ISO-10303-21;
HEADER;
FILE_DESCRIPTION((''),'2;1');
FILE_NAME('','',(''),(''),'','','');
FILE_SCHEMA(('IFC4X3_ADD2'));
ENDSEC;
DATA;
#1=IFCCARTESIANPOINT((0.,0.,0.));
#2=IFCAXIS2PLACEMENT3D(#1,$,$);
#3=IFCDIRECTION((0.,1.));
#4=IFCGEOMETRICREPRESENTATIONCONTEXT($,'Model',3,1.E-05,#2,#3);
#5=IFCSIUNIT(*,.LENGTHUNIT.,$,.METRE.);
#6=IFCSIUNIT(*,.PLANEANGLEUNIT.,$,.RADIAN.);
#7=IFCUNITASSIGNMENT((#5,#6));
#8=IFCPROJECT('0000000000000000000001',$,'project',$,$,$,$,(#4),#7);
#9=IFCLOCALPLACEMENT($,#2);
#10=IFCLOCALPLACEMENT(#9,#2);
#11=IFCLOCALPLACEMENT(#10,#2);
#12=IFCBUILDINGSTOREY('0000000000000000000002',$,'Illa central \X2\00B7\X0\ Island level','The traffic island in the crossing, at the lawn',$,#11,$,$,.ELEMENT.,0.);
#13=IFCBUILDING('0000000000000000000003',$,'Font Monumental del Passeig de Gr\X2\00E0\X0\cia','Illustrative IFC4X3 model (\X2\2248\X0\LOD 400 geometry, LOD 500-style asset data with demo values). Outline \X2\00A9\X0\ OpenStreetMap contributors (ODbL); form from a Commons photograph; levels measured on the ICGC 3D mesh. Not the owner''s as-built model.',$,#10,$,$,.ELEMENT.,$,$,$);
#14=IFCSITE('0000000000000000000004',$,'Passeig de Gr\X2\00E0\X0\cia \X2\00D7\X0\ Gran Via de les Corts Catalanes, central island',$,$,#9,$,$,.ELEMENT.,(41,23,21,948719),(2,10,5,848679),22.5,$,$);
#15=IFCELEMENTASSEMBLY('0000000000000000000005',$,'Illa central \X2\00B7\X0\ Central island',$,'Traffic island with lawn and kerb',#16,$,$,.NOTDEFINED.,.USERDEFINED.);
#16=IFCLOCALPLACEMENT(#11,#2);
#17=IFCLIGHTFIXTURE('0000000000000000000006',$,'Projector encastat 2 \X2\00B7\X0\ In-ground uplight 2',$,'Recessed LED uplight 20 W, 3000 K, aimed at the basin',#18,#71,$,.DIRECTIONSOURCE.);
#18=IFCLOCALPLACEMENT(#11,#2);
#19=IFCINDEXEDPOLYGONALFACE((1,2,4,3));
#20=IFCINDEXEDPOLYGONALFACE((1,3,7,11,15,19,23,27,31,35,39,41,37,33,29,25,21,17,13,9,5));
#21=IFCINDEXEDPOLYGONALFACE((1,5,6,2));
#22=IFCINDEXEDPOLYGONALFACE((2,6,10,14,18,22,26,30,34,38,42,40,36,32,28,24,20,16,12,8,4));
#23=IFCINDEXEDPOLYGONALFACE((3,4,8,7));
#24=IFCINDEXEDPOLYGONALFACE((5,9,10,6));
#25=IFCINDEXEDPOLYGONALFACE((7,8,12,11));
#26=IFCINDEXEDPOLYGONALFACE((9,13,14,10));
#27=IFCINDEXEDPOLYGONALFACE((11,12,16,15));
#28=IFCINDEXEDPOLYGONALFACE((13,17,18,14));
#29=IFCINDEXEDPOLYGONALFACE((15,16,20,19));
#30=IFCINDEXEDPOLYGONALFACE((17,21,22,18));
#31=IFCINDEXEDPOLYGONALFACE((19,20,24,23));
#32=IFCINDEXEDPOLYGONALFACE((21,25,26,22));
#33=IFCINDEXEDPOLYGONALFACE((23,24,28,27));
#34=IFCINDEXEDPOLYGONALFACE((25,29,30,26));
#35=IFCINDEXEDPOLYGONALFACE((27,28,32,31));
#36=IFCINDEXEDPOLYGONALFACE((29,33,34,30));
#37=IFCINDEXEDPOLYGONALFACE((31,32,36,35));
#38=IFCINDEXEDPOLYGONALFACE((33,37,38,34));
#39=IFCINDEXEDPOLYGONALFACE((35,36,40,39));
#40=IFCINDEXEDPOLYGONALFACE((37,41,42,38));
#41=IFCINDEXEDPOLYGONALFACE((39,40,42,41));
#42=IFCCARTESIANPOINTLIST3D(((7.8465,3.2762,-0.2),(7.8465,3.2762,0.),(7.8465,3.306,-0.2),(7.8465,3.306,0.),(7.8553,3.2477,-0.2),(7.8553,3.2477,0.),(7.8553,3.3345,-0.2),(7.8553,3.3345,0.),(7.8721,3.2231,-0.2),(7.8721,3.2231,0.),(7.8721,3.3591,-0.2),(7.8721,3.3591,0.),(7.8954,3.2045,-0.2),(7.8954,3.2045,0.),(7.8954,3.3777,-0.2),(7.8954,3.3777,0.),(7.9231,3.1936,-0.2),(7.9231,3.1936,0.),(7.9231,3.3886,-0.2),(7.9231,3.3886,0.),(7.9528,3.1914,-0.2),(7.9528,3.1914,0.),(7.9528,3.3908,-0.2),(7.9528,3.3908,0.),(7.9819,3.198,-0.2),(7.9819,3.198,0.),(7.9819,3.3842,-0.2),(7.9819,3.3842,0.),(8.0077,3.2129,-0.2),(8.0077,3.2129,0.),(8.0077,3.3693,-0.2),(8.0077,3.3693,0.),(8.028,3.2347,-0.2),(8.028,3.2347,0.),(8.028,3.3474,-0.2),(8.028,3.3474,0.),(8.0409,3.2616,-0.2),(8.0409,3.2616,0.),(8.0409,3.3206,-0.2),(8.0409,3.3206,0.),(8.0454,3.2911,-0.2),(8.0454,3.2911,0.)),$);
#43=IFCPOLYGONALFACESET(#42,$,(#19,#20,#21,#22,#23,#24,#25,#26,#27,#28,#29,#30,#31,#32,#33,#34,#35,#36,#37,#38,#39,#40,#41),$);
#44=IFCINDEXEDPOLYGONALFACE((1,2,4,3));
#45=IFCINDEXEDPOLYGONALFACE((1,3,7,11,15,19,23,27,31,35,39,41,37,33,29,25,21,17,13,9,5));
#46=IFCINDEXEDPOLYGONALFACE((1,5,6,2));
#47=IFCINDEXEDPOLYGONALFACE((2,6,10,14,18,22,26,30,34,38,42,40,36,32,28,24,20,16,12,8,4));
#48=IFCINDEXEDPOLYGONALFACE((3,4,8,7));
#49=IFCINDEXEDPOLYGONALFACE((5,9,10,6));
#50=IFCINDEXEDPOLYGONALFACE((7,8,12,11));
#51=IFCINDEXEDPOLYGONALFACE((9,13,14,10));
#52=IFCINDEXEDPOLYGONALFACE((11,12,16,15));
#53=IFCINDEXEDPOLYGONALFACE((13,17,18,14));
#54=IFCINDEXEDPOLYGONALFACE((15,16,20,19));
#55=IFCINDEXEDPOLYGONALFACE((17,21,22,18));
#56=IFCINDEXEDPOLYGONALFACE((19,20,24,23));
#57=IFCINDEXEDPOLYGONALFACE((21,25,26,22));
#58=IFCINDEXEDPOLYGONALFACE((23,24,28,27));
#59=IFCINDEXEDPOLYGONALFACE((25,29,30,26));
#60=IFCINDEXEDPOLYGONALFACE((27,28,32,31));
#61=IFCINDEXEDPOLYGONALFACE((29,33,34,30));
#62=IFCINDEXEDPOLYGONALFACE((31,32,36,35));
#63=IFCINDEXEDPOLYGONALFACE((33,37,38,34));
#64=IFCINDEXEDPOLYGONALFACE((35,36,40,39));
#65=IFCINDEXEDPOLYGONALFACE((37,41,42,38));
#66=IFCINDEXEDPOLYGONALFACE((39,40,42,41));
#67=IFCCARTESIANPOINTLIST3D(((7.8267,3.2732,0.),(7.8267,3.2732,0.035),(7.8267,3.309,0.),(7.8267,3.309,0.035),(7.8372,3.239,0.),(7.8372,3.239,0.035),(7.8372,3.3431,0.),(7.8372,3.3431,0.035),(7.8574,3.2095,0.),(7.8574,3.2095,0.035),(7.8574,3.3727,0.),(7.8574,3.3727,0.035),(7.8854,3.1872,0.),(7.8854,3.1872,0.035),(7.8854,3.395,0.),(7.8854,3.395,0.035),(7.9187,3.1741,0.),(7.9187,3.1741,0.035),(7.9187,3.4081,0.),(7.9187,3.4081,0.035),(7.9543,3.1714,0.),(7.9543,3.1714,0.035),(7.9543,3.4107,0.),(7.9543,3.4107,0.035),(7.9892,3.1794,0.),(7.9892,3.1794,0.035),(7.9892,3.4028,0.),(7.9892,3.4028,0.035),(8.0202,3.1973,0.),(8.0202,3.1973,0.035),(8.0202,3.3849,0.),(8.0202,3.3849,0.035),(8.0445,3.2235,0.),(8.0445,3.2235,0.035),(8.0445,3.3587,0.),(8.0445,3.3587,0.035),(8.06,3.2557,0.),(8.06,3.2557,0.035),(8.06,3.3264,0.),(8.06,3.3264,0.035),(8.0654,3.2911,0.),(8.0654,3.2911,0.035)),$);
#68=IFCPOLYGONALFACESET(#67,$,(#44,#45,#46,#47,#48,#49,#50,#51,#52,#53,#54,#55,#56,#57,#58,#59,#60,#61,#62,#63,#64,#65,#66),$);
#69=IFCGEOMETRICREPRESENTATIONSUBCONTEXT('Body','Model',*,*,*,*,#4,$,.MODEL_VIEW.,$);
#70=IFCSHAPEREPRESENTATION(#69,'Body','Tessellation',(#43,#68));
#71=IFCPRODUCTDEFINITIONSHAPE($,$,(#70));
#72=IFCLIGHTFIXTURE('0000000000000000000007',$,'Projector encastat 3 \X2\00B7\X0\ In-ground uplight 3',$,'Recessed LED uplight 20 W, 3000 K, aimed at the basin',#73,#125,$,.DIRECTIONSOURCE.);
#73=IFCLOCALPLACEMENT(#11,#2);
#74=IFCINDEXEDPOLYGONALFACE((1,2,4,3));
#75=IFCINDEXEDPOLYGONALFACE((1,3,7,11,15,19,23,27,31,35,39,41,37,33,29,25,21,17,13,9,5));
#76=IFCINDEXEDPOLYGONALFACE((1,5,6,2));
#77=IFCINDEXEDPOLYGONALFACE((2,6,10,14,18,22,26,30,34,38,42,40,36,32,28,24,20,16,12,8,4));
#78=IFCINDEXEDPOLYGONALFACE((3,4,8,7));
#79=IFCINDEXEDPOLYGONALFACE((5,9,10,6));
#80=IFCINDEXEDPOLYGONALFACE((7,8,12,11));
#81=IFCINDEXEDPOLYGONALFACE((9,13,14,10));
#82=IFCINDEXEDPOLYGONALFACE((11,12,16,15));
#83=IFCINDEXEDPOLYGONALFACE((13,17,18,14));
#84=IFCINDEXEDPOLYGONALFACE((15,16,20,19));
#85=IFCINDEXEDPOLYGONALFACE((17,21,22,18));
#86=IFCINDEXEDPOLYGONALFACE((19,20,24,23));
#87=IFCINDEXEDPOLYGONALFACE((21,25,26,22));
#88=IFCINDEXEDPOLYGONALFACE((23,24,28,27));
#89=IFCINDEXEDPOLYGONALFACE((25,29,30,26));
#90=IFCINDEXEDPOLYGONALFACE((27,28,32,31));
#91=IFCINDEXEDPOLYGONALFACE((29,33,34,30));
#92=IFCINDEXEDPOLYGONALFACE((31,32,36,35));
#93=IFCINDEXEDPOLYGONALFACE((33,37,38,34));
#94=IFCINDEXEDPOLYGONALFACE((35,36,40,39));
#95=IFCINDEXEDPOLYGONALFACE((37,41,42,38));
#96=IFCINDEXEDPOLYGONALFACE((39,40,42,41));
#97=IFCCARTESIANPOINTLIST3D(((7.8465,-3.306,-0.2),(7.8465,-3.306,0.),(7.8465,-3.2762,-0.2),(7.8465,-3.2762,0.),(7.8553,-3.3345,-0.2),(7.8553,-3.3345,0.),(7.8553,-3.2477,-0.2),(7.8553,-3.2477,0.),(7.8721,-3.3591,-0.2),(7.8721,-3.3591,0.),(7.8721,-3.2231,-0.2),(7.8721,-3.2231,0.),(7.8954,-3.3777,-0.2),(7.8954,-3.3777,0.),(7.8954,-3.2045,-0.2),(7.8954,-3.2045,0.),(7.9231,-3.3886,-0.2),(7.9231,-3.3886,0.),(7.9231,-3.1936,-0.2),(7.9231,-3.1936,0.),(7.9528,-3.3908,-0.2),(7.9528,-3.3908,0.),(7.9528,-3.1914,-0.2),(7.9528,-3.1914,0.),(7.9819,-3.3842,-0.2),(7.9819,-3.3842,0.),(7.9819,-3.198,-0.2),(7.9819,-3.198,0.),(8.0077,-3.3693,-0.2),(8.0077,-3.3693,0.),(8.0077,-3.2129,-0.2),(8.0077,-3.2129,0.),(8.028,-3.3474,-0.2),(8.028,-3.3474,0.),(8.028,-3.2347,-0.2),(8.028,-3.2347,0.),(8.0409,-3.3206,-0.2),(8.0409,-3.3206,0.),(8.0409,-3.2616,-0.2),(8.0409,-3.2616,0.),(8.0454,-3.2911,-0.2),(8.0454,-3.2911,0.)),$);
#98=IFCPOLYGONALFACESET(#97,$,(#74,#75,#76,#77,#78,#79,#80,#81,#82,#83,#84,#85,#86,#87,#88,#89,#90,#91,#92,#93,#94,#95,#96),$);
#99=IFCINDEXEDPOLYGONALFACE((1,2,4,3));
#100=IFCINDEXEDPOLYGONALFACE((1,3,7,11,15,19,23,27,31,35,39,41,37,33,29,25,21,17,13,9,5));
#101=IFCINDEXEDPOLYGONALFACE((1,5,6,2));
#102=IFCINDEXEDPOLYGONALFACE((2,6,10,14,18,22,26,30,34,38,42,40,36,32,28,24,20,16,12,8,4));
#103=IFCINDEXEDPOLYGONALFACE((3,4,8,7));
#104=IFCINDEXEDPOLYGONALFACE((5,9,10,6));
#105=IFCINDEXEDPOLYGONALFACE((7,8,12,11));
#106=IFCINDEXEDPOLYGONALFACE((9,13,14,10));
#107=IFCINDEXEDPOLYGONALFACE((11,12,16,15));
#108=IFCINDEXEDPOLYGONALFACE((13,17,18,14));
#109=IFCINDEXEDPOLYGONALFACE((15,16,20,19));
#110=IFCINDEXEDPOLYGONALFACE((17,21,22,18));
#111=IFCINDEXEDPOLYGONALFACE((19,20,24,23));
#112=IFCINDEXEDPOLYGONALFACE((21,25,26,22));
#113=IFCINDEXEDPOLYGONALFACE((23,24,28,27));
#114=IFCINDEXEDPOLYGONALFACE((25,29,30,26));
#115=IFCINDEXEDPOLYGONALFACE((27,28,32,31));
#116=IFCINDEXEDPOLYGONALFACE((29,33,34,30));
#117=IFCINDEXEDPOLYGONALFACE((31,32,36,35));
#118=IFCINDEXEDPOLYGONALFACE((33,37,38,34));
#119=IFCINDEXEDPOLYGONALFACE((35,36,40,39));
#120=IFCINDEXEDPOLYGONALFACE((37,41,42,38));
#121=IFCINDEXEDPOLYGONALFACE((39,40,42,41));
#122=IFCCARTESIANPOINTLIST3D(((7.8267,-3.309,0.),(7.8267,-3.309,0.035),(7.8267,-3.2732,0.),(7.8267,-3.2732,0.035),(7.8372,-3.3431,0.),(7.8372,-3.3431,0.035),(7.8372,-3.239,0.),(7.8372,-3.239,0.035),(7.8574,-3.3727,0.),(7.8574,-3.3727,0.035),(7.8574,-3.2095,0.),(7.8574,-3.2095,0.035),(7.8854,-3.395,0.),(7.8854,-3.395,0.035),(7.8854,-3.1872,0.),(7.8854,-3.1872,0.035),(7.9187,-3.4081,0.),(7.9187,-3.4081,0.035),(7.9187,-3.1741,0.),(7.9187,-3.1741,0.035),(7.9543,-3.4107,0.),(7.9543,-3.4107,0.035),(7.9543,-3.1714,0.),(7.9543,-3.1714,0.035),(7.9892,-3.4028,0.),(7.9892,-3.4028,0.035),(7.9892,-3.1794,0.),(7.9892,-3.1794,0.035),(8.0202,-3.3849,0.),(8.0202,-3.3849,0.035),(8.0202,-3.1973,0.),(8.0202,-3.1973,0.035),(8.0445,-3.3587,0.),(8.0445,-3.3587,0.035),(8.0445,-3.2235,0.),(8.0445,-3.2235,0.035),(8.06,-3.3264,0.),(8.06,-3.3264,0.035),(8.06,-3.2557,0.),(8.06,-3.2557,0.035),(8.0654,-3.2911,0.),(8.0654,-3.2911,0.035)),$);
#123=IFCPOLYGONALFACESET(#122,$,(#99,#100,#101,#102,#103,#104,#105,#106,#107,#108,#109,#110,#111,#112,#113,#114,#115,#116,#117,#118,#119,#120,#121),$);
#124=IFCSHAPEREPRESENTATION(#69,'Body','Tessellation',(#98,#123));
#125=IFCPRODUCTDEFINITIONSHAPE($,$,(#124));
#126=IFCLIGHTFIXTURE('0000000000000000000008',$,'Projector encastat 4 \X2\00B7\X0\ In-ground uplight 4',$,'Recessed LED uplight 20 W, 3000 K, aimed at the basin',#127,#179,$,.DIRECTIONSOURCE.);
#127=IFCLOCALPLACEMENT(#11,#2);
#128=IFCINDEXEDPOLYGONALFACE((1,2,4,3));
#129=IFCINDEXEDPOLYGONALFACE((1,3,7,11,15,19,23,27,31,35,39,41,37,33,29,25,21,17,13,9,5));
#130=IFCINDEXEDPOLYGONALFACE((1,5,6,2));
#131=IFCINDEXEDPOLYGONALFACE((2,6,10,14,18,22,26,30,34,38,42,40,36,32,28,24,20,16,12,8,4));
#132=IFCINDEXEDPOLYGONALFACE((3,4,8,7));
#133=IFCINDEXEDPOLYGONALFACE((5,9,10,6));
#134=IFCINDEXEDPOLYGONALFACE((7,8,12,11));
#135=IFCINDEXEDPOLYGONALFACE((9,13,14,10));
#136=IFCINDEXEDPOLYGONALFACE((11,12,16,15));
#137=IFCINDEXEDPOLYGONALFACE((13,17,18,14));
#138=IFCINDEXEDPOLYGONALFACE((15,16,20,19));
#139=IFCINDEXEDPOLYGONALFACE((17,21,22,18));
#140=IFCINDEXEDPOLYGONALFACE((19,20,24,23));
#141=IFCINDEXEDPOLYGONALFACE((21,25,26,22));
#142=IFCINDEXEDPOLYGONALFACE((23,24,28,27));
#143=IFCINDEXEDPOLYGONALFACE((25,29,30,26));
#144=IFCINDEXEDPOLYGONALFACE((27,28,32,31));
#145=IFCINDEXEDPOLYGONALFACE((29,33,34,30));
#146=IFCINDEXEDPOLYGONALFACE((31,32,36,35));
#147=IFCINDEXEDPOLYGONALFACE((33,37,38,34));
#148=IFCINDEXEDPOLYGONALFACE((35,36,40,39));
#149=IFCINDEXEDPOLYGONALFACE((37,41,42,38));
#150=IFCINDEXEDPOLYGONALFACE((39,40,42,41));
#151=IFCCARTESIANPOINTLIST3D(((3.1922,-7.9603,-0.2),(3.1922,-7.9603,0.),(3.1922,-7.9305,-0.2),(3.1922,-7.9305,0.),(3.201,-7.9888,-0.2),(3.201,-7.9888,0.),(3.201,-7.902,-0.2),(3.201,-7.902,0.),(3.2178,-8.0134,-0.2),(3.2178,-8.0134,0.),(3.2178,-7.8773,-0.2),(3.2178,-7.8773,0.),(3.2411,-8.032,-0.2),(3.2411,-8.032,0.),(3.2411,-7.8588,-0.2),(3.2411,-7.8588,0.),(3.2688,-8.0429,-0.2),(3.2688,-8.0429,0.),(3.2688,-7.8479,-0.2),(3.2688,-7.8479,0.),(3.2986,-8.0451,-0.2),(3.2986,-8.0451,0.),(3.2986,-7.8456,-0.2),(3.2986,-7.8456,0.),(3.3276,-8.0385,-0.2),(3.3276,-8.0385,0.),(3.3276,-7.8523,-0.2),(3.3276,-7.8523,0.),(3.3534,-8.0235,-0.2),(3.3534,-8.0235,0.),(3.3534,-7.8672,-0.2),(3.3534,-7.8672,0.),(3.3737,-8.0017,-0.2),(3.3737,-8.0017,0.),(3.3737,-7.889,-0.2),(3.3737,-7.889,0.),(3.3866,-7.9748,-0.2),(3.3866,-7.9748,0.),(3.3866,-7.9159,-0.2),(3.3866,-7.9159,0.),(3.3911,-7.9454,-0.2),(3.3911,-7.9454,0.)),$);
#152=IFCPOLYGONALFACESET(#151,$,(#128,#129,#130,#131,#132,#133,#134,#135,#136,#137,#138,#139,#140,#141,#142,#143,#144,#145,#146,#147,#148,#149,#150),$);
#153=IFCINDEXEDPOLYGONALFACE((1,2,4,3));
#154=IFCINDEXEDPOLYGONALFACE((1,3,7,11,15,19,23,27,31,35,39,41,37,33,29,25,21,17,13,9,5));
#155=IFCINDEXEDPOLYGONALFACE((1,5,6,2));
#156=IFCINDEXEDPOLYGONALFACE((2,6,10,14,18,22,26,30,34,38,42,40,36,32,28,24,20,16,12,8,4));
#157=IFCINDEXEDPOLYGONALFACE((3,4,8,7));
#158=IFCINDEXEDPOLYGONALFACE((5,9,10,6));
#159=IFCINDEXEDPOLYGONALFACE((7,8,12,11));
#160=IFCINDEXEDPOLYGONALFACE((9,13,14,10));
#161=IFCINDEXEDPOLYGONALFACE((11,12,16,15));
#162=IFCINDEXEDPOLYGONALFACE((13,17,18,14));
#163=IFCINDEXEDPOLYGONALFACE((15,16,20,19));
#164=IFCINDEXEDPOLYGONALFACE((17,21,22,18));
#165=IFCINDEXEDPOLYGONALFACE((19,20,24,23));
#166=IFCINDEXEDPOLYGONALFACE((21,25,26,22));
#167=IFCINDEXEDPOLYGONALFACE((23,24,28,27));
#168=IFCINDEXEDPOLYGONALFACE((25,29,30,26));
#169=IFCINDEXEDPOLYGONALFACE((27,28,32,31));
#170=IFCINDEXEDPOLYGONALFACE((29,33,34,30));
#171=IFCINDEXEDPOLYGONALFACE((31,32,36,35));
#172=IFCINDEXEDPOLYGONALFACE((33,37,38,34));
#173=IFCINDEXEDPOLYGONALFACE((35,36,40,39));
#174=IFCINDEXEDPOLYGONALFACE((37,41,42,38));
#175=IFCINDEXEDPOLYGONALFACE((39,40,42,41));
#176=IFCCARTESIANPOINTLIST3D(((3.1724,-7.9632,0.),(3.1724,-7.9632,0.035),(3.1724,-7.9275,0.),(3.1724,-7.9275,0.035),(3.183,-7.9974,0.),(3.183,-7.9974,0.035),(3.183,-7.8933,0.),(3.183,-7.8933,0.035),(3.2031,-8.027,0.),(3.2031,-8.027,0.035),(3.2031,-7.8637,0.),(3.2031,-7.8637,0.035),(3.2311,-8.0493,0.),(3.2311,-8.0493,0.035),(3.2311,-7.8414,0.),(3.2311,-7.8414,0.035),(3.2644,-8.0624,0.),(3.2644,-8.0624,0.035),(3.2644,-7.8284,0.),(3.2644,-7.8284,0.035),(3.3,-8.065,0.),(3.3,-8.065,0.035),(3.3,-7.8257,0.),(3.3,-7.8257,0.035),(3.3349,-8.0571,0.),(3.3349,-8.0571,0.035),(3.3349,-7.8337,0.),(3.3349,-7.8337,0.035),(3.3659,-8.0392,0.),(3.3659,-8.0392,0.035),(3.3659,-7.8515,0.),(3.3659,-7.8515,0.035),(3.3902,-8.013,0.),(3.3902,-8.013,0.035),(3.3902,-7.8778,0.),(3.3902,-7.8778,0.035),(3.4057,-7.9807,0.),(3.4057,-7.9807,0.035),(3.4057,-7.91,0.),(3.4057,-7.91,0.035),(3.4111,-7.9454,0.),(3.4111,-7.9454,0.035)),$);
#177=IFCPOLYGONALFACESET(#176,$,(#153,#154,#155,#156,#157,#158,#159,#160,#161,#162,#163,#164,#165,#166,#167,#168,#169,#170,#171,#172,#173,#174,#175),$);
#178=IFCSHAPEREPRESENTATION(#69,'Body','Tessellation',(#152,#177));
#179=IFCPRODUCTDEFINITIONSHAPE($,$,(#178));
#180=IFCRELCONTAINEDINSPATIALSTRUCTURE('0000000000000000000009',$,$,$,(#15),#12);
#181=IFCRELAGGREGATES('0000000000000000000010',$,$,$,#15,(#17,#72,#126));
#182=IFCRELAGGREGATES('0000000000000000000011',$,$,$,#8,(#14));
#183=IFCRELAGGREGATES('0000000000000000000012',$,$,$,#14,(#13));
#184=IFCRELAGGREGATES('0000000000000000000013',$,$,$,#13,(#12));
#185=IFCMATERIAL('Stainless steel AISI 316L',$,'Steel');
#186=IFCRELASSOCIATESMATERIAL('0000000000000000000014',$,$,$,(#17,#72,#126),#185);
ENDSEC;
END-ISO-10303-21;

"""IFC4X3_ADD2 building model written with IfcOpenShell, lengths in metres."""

from ifc_helpers import new_model, si_unit, direction, frame, origin, origin_2d_with_axis, place, context, subcontext, project, spatial, circle, extrude, material, element, aggregate, save


model = new_model("IFC4X3_ADD2")

# Units and contexts
model_context = context("Model", 3, precision=1e-05, world=origin(), true_north=direction((0.0, 1.0)))
body_context = subcontext(model_context, "Body", "Model", "MODEL_VIEW")
ifc_project = project(units=[si_unit("LENGTHUNIT", "METRE"), si_unit("PLANEANGLEUNIT", "RADIAN")], contexts=[model_context])

# Site, building, storey
site_placement = place(None, origin())
site = spatial("IfcSite", under=ifc_project, at=site_placement, Name="Passeig de Gràcia × Gran Via de les Corts Catalanes, central island", CompositionType="ELEMENT", RefLatitude=(41, 23, 21, 948719), RefLongitude=(2, 10, 5, 848679), RefElevation=22.5)
building_placement = place(site_placement, origin())
building = spatial("IfcBuilding", under=site, at=building_placement, Name="Font Monumental del Passeig de Gràcia", Description="Illustrative IFC4X3 model (≈LOD 400 geometry, LOD 500-style asset data with demo values). Outline © OpenStreetMap contributors (ODbL); form from a Commons photograph; levels measured on the ICGC 3D mesh. Not the owner's as-built model.", CompositionType="ELEMENT")
storey_placement = place(building_placement, origin())
storey = spatial("IfcBuildingStorey", under=building, at=storey_placement, Name="Illa central · Island level", Description="The traffic island in the crossing, at the lawn", CompositionType="ELEMENT", Elevation=0.0)

# Shared definitions
ifc_material_1 = material(Name="Stainless steel AISI 316L", Category="Steel")

# Element assembly, light fixtures
assembly_1_placement = place(building_placement, origin())
assembly_1 = element("IfcElementAssembly", 1, at=assembly_1_placement, inside=storey, Name="Illa central · Central island", ObjectType="Traffic island with lawn and kerb", AssemblyPlace="NOTDEFINED", PredefinedType="USERDEFINED")
light_fixture_1_placement = place(building_placement, origin())
light_fixture_1 = element("IfcLightFixture", 2, at=light_fixture_1_placement, material=ifc_material_1, Name="Projector encastat 2 · In-ground uplight 2", ObjectType="Recessed LED uplight 20 W, 3000 K, aimed at the basin", PredefinedType="DIRECTIONSOURCE", context=body_context, shape_type="SweptSolid", body=[
    extrude(circle(Radius=0.1, at=origin_2d_with_axis()), frame((7.9454, 3.2911, -0.2)), (0.0, 0.0, 1.0), 0.2),
    extrude(circle(Radius=0.12, at=origin_2d_with_axis()), frame((7.9454, 3.2911, 0.0)), (0.0, 0.0, 1.0), 0.035),
])
light_fixture_2_placement = place(building_placement, origin())
light_fixture_2 = element("IfcLightFixture", 3, at=light_fixture_2_placement, material=ifc_material_1, Name="Projector encastat 3 · In-ground uplight 3", ObjectType="Recessed LED uplight 20 W, 3000 K, aimed at the basin", PredefinedType="DIRECTIONSOURCE", context=body_context, shape_type="SweptSolid", body=[
    extrude(circle(Radius=0.1, at=origin_2d_with_axis()), frame((7.9454, -3.2911, -0.2)), (0.0, 0.0, 1.0), 0.2),
    extrude(circle(Radius=0.12, at=origin_2d_with_axis()), frame((7.9454, -3.2911, 0.0)), (0.0, 0.0, 1.0), 0.035),
])
light_fixture_3_placement = place(building_placement, origin())
light_fixture_3 = element("IfcLightFixture", 4, at=light_fixture_3_placement, material=ifc_material_1, Name="Projector encastat 4 · In-ground uplight 4", ObjectType="Recessed LED uplight 20 W, 3000 K, aimed at the basin", PredefinedType="DIRECTIONSOURCE", context=body_context, shape_type="SweptSolid", body=[
    extrude(circle(Radius=0.1, at=origin_2d_with_axis()), frame((3.2911, -7.9454, -0.2)), (0.0, 0.0, 1.0), 0.2),
    extrude(circle(Radius=0.12, at=origin_2d_with_axis()), frame((3.2911, -7.9454, 0.0)), (0.0, 0.0, 1.0), 0.035),
])

aggregate(assembly_1, [light_fixture_1, light_fixture_2, light_fixture_3])

save(model, "model.ifc")
